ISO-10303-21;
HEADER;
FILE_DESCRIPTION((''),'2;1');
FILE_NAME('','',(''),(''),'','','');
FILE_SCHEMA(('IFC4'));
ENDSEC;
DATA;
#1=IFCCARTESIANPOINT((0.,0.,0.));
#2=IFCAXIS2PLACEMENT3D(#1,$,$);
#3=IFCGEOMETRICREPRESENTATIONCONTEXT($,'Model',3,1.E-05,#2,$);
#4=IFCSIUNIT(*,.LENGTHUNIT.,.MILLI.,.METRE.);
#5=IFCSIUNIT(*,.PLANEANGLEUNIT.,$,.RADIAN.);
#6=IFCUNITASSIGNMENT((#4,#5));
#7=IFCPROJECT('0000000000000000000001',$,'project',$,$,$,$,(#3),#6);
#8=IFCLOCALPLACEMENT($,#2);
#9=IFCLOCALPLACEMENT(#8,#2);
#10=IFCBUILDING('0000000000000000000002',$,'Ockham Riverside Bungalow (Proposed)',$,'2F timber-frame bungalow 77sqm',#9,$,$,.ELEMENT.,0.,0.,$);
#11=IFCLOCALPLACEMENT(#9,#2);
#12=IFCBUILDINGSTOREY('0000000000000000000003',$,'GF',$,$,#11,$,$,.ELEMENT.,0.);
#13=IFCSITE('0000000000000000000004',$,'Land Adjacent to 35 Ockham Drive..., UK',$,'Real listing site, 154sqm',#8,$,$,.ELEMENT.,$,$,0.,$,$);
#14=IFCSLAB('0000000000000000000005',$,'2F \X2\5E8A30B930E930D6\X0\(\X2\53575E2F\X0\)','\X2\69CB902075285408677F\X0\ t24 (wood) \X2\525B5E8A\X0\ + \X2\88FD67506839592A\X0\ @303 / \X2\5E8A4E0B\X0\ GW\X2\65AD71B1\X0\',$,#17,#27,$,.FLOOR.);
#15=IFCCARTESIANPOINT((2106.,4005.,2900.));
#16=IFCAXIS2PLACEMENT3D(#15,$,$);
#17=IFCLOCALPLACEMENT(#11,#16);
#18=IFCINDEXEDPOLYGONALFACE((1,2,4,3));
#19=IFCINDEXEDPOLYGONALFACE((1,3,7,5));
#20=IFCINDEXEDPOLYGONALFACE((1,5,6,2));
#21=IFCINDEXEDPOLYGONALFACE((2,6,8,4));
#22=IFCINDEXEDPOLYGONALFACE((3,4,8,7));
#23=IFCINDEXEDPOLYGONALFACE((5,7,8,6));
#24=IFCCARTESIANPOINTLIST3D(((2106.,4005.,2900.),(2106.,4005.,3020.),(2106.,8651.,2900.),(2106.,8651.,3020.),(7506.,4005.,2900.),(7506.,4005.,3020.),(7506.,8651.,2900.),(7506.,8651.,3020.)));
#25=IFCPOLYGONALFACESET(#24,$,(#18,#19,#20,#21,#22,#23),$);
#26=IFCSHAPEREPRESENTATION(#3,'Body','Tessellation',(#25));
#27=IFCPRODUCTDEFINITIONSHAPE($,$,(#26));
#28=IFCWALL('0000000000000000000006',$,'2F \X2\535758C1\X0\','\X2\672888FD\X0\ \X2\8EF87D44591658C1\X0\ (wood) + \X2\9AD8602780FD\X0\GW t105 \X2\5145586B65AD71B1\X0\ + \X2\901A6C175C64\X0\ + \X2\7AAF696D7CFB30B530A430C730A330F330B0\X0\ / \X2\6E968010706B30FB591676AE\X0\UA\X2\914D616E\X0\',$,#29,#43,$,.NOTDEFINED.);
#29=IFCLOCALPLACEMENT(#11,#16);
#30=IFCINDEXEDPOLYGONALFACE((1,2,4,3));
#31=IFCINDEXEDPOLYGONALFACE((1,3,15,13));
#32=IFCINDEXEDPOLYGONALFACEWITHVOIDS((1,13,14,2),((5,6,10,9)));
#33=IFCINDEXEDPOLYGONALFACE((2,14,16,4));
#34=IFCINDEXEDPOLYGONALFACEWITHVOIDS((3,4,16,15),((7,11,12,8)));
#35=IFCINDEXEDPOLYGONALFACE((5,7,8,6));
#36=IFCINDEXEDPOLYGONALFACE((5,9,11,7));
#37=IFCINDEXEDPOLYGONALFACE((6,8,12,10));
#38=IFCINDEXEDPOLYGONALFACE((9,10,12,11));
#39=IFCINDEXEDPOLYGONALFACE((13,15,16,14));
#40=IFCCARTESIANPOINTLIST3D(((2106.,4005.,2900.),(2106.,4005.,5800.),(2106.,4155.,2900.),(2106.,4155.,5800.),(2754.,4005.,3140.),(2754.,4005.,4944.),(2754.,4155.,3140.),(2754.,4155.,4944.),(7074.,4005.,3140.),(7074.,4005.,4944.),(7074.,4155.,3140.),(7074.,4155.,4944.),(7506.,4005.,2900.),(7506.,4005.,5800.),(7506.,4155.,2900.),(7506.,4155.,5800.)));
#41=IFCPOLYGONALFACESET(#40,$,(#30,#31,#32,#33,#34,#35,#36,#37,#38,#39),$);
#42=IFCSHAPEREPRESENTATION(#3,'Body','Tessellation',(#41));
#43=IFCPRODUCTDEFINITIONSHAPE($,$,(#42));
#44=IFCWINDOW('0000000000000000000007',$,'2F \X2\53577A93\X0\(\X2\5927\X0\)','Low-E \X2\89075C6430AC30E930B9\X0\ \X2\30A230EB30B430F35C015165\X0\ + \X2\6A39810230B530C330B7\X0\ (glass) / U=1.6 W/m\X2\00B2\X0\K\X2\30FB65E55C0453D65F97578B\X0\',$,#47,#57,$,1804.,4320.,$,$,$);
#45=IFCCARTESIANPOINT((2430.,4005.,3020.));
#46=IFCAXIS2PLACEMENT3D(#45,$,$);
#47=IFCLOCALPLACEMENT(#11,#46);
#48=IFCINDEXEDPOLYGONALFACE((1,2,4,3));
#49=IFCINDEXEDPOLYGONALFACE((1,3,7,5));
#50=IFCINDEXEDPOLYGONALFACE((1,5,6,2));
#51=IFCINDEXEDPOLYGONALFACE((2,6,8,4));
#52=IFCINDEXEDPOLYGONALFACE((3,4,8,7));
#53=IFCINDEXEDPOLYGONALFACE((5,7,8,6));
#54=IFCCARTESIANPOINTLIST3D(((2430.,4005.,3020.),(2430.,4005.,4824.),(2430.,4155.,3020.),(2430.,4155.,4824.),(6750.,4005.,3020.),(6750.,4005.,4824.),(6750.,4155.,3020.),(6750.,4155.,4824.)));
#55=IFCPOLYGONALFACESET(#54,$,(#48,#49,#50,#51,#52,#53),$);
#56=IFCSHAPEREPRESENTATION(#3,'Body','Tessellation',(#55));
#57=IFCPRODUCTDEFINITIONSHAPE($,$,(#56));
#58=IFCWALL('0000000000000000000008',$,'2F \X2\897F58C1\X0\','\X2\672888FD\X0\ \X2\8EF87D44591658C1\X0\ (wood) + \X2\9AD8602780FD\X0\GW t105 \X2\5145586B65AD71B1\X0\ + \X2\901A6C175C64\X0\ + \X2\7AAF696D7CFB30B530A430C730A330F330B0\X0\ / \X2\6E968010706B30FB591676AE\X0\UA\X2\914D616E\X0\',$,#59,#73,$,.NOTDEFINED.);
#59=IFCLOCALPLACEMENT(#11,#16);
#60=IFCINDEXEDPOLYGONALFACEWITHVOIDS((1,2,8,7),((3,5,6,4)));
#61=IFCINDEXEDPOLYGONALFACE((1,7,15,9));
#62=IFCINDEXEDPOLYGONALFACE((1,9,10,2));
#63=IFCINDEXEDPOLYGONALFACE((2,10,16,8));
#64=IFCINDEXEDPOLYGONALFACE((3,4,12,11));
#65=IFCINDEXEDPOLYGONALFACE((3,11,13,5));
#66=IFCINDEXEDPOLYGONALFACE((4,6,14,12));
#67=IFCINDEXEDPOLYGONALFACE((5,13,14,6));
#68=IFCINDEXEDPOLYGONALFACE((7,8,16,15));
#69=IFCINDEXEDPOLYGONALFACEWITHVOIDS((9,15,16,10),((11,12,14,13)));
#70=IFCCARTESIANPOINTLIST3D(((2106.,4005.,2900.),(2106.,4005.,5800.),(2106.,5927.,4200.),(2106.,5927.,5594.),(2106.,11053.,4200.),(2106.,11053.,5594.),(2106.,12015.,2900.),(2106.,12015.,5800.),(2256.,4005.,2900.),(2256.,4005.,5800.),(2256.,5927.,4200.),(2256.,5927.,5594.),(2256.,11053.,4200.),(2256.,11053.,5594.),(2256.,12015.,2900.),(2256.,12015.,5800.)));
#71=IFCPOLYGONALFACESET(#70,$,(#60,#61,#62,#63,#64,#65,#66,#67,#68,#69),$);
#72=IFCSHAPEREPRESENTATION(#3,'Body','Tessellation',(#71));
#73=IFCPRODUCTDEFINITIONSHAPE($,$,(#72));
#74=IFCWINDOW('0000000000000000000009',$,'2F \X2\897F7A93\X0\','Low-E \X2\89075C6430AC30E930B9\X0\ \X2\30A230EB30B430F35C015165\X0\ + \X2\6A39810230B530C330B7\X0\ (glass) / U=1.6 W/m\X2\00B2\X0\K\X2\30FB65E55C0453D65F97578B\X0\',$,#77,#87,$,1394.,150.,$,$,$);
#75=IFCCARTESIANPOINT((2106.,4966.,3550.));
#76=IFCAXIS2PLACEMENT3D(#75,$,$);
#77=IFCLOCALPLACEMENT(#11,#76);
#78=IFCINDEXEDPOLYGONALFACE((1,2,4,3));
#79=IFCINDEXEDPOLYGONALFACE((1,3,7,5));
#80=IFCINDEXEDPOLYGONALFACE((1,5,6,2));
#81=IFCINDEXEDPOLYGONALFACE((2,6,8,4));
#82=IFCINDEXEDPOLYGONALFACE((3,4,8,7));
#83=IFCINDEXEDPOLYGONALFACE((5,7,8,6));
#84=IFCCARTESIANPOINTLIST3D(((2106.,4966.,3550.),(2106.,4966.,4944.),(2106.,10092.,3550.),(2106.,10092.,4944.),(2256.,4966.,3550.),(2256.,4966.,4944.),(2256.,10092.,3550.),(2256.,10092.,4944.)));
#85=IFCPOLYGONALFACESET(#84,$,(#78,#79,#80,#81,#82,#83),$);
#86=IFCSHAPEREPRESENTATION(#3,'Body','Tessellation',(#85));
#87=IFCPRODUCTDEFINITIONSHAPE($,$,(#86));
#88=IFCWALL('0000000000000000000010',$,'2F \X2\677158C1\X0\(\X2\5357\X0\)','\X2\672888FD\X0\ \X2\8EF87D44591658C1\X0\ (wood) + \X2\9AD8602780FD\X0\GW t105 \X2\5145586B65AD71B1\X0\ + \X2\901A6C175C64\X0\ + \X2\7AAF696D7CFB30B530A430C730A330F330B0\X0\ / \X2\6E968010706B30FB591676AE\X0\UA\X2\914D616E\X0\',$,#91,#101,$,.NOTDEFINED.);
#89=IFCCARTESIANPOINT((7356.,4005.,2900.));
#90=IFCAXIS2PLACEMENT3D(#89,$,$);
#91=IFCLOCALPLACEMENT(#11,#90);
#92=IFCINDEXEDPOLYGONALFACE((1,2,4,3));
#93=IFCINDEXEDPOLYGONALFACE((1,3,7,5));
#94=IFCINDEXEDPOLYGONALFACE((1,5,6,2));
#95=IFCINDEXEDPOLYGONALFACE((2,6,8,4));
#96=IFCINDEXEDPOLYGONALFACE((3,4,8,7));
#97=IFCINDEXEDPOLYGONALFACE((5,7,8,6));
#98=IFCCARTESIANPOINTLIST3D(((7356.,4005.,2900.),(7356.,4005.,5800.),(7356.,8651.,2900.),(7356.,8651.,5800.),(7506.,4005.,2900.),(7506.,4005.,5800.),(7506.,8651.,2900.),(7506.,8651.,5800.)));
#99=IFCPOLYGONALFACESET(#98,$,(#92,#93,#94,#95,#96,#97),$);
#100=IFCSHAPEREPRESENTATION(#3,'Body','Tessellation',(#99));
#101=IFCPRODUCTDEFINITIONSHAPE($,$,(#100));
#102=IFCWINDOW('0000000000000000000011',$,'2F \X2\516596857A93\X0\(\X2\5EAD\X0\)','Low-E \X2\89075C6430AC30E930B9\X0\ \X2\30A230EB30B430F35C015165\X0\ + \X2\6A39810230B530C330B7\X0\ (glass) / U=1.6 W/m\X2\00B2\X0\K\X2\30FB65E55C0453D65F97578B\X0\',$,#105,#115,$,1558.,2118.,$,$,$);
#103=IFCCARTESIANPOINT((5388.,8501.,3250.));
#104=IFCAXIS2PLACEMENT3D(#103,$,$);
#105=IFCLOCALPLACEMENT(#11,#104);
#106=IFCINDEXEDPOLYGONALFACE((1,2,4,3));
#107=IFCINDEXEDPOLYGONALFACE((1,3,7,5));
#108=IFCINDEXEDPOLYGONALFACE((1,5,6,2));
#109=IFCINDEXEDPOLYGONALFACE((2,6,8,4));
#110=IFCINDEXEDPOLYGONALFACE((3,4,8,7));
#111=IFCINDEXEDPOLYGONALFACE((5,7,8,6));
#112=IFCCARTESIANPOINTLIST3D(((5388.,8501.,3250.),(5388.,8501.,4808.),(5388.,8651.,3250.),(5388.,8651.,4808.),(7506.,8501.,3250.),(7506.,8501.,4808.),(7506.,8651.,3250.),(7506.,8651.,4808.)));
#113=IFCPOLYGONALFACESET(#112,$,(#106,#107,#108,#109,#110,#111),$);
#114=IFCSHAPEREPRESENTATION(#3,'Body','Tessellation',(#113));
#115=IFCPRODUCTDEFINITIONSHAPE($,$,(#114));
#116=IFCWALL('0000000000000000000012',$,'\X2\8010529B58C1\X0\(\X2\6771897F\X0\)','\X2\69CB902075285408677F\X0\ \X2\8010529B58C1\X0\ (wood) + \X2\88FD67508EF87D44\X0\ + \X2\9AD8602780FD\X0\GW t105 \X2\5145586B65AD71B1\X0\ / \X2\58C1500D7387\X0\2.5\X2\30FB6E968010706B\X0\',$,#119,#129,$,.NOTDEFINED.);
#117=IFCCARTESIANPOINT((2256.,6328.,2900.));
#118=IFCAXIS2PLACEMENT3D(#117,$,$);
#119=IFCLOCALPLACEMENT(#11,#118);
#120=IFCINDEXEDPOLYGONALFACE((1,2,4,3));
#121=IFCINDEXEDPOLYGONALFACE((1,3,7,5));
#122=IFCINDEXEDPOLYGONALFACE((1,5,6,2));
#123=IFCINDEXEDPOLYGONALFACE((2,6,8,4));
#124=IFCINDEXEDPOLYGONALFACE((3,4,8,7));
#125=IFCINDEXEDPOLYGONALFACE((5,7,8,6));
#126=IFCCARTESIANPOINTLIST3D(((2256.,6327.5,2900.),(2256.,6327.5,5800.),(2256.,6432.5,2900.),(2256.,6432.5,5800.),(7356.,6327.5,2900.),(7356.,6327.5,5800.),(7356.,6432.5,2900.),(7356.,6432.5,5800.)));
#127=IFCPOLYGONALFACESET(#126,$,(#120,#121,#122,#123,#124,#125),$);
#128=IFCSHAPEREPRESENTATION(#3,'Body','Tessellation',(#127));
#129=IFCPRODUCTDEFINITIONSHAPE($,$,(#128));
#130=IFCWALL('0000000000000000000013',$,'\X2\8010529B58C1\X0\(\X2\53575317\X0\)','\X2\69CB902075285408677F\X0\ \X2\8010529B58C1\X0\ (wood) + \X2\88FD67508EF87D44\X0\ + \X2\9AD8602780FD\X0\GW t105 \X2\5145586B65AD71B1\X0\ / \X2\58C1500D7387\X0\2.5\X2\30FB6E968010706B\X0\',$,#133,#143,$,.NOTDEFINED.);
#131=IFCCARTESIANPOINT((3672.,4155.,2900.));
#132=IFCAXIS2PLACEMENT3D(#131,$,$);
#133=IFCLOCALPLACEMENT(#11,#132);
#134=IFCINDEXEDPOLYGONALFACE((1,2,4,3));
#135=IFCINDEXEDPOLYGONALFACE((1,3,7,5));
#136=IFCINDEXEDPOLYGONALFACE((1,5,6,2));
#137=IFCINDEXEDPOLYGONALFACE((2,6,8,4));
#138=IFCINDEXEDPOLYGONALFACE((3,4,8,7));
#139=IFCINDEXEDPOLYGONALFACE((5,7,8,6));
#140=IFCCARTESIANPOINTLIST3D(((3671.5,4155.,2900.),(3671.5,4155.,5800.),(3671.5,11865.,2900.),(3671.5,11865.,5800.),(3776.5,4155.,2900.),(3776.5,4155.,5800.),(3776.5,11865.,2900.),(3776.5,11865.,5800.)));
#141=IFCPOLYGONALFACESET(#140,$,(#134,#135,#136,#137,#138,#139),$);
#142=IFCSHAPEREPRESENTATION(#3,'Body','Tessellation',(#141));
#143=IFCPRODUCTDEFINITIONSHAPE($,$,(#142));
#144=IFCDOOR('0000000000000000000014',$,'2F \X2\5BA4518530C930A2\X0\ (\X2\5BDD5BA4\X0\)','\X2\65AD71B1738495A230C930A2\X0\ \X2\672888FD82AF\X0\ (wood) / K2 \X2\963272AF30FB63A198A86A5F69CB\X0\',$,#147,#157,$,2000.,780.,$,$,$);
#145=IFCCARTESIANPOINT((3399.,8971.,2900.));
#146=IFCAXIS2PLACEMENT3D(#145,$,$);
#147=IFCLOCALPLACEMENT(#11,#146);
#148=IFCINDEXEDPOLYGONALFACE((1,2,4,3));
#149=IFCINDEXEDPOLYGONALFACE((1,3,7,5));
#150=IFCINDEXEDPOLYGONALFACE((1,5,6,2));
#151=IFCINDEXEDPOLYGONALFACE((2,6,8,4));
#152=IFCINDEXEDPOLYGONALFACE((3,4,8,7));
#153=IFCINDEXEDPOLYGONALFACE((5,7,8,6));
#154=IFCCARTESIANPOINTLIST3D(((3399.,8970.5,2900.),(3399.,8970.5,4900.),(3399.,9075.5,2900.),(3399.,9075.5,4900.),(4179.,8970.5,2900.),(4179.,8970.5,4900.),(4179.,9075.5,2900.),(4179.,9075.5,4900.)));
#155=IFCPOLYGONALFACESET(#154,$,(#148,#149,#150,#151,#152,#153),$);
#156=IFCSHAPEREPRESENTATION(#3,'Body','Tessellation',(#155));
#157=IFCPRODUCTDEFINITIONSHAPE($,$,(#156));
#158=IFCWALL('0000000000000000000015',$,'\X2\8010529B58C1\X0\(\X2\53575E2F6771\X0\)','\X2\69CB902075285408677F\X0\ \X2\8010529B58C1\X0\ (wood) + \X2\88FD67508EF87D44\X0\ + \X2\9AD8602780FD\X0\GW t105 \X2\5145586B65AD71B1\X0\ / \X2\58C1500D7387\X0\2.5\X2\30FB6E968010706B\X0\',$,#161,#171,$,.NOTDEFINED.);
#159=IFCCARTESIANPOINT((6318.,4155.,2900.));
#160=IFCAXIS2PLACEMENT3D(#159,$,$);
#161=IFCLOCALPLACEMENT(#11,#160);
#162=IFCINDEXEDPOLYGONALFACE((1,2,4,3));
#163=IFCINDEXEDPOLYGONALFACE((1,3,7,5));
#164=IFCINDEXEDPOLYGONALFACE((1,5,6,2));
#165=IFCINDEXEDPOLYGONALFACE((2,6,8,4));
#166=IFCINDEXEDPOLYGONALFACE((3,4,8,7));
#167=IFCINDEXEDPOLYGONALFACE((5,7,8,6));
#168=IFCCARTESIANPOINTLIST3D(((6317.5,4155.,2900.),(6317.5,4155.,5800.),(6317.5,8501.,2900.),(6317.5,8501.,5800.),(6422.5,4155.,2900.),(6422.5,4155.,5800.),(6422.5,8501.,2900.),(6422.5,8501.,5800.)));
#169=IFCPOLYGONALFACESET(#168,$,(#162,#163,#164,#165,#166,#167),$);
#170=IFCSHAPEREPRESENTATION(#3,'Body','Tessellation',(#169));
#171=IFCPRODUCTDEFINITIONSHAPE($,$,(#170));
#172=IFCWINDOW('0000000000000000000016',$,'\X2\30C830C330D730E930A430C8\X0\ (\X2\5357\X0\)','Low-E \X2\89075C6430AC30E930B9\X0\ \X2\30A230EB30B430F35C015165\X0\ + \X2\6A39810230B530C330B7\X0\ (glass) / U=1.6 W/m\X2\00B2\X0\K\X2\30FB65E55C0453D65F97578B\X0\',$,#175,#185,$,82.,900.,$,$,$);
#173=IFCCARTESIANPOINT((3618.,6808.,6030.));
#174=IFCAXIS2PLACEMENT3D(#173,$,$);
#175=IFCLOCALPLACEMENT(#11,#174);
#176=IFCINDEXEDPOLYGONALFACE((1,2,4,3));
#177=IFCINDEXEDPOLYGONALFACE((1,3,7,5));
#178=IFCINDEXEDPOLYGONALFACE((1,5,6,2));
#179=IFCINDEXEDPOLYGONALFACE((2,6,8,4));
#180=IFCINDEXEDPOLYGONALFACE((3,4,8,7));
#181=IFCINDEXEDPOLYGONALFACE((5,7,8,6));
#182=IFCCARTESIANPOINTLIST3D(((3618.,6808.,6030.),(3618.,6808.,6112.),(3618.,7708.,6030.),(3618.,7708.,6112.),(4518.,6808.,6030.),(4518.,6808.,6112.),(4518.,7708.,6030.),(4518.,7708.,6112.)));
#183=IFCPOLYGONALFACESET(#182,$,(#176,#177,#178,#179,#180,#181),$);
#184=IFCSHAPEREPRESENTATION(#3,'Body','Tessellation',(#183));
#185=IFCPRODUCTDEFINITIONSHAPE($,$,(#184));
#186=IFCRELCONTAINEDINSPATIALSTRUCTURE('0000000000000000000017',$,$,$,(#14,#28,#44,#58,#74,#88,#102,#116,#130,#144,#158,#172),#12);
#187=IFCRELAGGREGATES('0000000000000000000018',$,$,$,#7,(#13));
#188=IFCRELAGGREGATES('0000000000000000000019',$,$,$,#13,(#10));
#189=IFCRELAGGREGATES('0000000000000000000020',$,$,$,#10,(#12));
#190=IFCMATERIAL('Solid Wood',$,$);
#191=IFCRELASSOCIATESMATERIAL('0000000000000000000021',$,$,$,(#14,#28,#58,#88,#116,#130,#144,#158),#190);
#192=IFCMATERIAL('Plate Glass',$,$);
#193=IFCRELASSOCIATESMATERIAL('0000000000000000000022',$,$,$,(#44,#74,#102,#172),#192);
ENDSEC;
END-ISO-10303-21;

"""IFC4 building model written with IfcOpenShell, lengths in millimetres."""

from ifc_helpers import new_model, si_unit, frame, frame_2d, origin, place, context, project, spatial, rectangle, extrude, material, element, fill, save


model = new_model("IFC4")

# Units and contexts
model_context = context("Model", 3, precision=1e-05, world=origin())
ifc_project = project(units=[si_unit("LENGTHUNIT", "METRE", prefix="MILLI"), si_unit("PLANEANGLEUNIT", "RADIAN")], contexts=[model_context])

# Site, building, storey
site_placement = place(None, origin())
site = spatial("IfcSite", under=ifc_project, at=site_placement, Name="Land Adjacent to 35 Ockham Drive..., UK", ObjectType="Real listing site, 154sqm", CompositionType="ELEMENT", RefElevation=0.0)
building_placement = place(site_placement, origin())
building = spatial("IfcBuilding", under=site, at=building_placement, Name="Ockham Riverside Bungalow (Proposed)", ObjectType="2F timber-frame bungalow 77sqm", CompositionType="ELEMENT", ElevationOfRefHeight=0.0, ElevationOfTerrain=0.0)
storey_placement = place(building_placement, origin())
storey = spatial("IfcBuildingStorey", under=building, at=storey_placement, Name="GF", CompositionType="ELEMENT", Elevation=0.0)

# Slab
ifc_material_1 = material(Name="Solid Wood")
slab_placement = place(storey_placement, frame((2106.0, 4005.0, 2900.0)))
element("IfcSlab", 1, at=slab_placement, inside=storey, material=ifc_material_1, Name="2F 床スラブ(南帯)", Description="構造用合板 t24 (wood) 剛床 + 製材根太 @303 / 床下 GW断熱", PredefinedType="FLOOR", context=model_context, shape_type="SweptSolid", body=[
    extrude(rectangle(XDim=5400.0, YDim=4646.0, at=frame_2d((2700.0, 2323.0))), frame((2106.0, 4005.0, 2900.0)), (0.0, 0.0, 1.0), 120.0),
])

# Walls, openings, windows
wall_1_placement = place(storey_placement, frame((2106.0, 4005.0, 2900.0)))
wall_1 = element("IfcWall", 2, at=wall_1_placement, inside=storey, material=ifc_material_1, Name="2F 南壁", Description="木製 軸組外壁 (wood) + 高性能GW t105 充填断熱 + 通気層 + 窯業系サイディング / 準耐火・外皮UA配慮", PredefinedType="NOTDEFINED", context=model_context, shape_type="SweptSolid", body=[
    extrude(rectangle(XDim=5400.0, YDim=150.0, at=frame_2d((2700.0, 75.0))), frame((2106.0, 4005.0, 2900.0)), (0.0, 0.0, 1.0), 2900.0),
])
opening_1_placement = place(storey_placement, frame((2430.0, 4005.0, 3020.0)))
opening_1 = element("IfcOpeningElement", 3, at=opening_1_placement, cuts=wall_1, PredefinedType="NOTDEFINED", context=model_context, shape_type="SweptSolid", body=[
    extrude(rectangle(XDim=4320.0, YDim=150.0, at=frame_2d((2160.0, 75.0))), frame((2430.0, 4005.0, 3020.0)), (0.0, 0.0, 1.0), 1804.0),
])
ifc_material_2 = material(Name="Plate Glass")
window_1_placement = place(storey_placement, frame((2430.0, 4005.0, 3020.0)))
window_1 = element("IfcWindow", 4, at=window_1_placement, inside=storey, material=ifc_material_2, Name="2F 南窓(大)", Description="Low-E 複層ガラス アルゴン封入 + 樹脂サッシ (glass) / U=1.6 W/m²K・日射取得型", OverallHeight=1804.0, OverallWidth=4320.0, context=model_context, shape_type="SweptSolid", body=[
    extrude(rectangle(XDim=4320.0, YDim=150.0, at=frame_2d((2160.0, 75.0))), frame((2430.0, 4005.0, 3020.0)), (0.0, 0.0, 1.0), 1804.0),
])
fill(opening_1, window_1)
wall_2_placement = place(storey_placement, frame((2106.0, 4005.0, 2900.0)))
wall_2 = element("IfcWall", 5, at=wall_2_placement, inside=storey, material=ifc_material_1, Name="2F 西壁", Description="木製 軸組外壁 (wood) + 高性能GW t105 充填断熱 + 通気層 + 窯業系サイディング / 準耐火・外皮UA配慮", PredefinedType="NOTDEFINED", context=model_context, shape_type="SweptSolid", body=[
    extrude(rectangle(XDim=150.0, YDim=8010.0, at=frame_2d((75.0, 4005.0))), frame((2106.0, 4005.0, 2900.0)), (0.0, 0.0, 1.0), 2900.0),
])
opening_2_placement = place(storey_placement, frame((2106.0, 4966.0, 3550.0)))
opening_2 = element("IfcOpeningElement", 6, at=opening_2_placement, cuts=wall_2, PredefinedType="NOTDEFINED", context=model_context, shape_type="SweptSolid", body=[
    extrude(rectangle(XDim=150.0, YDim=5126.0, at=frame_2d((75.0, 2563.0))), frame((2106.0, 4966.0, 3550.0)), (0.0, 0.0, 1.0), 1394.0),
])
window_2_placement = place(storey_placement, frame((2106.0, 4966.0, 3550.0)))
window_2 = element("IfcWindow", 7, at=window_2_placement, inside=storey, material=ifc_material_2, Name="2F 西窓", Description="Low-E 複層ガラス アルゴン封入 + 樹脂サッシ (glass) / U=1.6 W/m²K・日射取得型", OverallHeight=1394.0, OverallWidth=150.0, context=model_context, shape_type="SweptSolid", body=[
    extrude(rectangle(XDim=150.0, YDim=5126.0, at=frame_2d((75.0, 2563.0))), frame((2106.0, 4966.0, 3550.0)), (0.0, 0.0, 1.0), 1394.0),
])
fill(opening_2, window_2)
wall_3_placement = place(storey_placement, frame((7356.0, 4005.0, 2900.0)))
wall_3 = element("IfcWall", 8, at=wall_3_placement, inside=storey, material=ifc_material_1, Name="2F 東壁(南)", Description="木製 軸組外壁 (wood) + 高性能GW t105 充填断熱 + 通気層 + 窯業系サイディング / 準耐火・外皮UA配慮", PredefinedType="NOTDEFINED", context=model_context, shape_type="SweptSolid", body=[
    extrude(rectangle(XDim=150.0, YDim=4646.0, at=frame_2d((75.0, 2323.0))), frame((7356.0, 4005.0, 2900.0)), (0.0, 0.0, 1.0), 2900.0),
])
opening_3_placement = place(storey_placement, frame((5388.0, 8501.0, 3250.0)))
opening_3 = element("IfcOpeningElement", 9, at=opening_3_placement, cuts=wall_3, PredefinedType="NOTDEFINED", context=model_context, shape_type="SweptSolid", body=[
    extrude(rectangle(XDim=2118.0, YDim=150.0, at=frame_2d((1059.0, 75.0))), frame((5388.0, 8501.0, 3250.0)), (0.0, 0.0, 1.0), 1558.0),
])
window_3_placement = place(storey_placement, frame((5388.0, 8501.0, 3250.0)))
window_3 = element("IfcWindow", 10, at=window_3_placement, inside=storey, material=ifc_material_2, Name="2F 入隅窓(庭)", Description="Low-E 複層ガラス アルゴン封入 + 樹脂サッシ (glass) / U=1.6 W/m²K・日射取得型", OverallHeight=1558.0, OverallWidth=2118.0, context=model_context, shape_type="SweptSolid", body=[
    extrude(rectangle(XDim=2118.0, YDim=150.0, at=frame_2d((1059.0, 75.0))), frame((5388.0, 8501.0, 3250.0)), (0.0, 0.0, 1.0), 1558.0),
])
fill(opening_3, window_3)

# Wall
wall_4_placement = place(storey_placement, frame((2256.0, 6328.0, 2900.0)))
element("IfcWall", 11, at=wall_4_placement, inside=storey, material=ifc_material_1, Name="耐力壁(東西)", Description="構造用合板 耐力壁 (wood) + 製材軸組 + 高性能GW t105 充填断熱 / 壁倍率2.5・準耐火", PredefinedType="NOTDEFINED", context=model_context, shape_type="SweptSolid", body=[
    extrude(rectangle(XDim=5100.0, YDim=105.0, at=frame_2d((2550.0, 52.0))), frame((2256.0, 6328.0, 2900.0)), (0.0, 0.0, 1.0), 2900.0),
])

# Wall, opening, door
wall_5_placement = place(storey_placement, frame((3672.0, 4155.0, 2900.0)))
wall_5 = element("IfcWall", 12, at=wall_5_placement, inside=storey, material=ifc_material_1, Name="耐力壁(南北)", Description="構造用合板 耐力壁 (wood) + 製材軸組 + 高性能GW t105 充填断熱 / 壁倍率2.5・準耐火", PredefinedType="NOTDEFINED", context=model_context, shape_type="SweptSolid", body=[
    extrude(rectangle(XDim=105.0, YDim=7710.0, at=frame_2d((52.0, 3855.0))), frame((3672.0, 4155.0, 2900.0)), (0.0, 0.0, 1.0), 2900.0),
])
opening_4_placement = place(storey_placement, frame((3399.0, 8971.0, 2900.0)))
opening_4 = element("IfcOpeningElement", 13, at=opening_4_placement, cuts=wall_5, PredefinedType="NOTDEFINED", context=model_context, shape_type="SweptSolid", body=[
    extrude(rectangle(XDim=780.0, YDim=105.0, at=frame_2d((390.0, 52.0))), frame((3399.0, 8971.0, 2900.0)), (0.0, 0.0, 1.0), 2000.0),
])
door_placement = place(storey_placement, frame((3399.0, 8971.0, 2900.0)))
door = element("IfcDoor", 14, at=door_placement, inside=storey, material=ifc_material_1, Name="2F 室内ドア (寝室)", Description="断熱玄関ドア 木製芯 (wood) / K2 防犯・採風機構", OverallHeight=2000.0, OverallWidth=780.0, context=model_context, shape_type="SweptSolid", body=[
    extrude(rectangle(XDim=780.0, YDim=105.0, at=frame_2d((390.0, 52.0))), frame((3399.0, 8971.0, 2900.0)), (0.0, 0.0, 1.0), 2000.0),
])
fill(opening_4, door)

# Wall
wall_6_placement = place(storey_placement, frame((6318.0, 4155.0, 2900.0)))
element("IfcWall", 15, at=wall_6_placement, inside=storey, material=ifc_material_1, Name="耐力壁(南帯東)", Description="構造用合板 耐力壁 (wood) + 製材軸組 + 高性能GW t105 充填断熱 / 壁倍率2.5・準耐火", PredefinedType="NOTDEFINED", context=model_context, shape_type="SweptSolid", body=[
    extrude(rectangle(XDim=105.0, YDim=4346.0, at=frame_2d((52.0, 2173.0))), frame((6318.0, 4155.0, 2900.0)), (0.0, 0.0, 1.0), 2900.0),
])

# Window
window_4_placement = place(storey_placement, frame((3618.0, 6808.0, 6030.0)))
element("IfcWindow", 16, at=window_4_placement, inside=storey, material=ifc_material_2, Name="トップライト (南)", Description="Low-E 複層ガラス アルゴン封入 + 樹脂サッシ (glass) / U=1.6 W/m²K・日射取得型", OverallHeight=82.0, OverallWidth=900.0, context=model_context, shape_type="SweptSolid", body=[
    extrude(rectangle(XDim=900.0, YDim=900.0, at=frame_2d((450.0, 450.0))), frame((3618.0, 6808.0, 6030.0)), (0.0, 0.0, 1.0), 82.0),
])

save(model, "model.ifc")
